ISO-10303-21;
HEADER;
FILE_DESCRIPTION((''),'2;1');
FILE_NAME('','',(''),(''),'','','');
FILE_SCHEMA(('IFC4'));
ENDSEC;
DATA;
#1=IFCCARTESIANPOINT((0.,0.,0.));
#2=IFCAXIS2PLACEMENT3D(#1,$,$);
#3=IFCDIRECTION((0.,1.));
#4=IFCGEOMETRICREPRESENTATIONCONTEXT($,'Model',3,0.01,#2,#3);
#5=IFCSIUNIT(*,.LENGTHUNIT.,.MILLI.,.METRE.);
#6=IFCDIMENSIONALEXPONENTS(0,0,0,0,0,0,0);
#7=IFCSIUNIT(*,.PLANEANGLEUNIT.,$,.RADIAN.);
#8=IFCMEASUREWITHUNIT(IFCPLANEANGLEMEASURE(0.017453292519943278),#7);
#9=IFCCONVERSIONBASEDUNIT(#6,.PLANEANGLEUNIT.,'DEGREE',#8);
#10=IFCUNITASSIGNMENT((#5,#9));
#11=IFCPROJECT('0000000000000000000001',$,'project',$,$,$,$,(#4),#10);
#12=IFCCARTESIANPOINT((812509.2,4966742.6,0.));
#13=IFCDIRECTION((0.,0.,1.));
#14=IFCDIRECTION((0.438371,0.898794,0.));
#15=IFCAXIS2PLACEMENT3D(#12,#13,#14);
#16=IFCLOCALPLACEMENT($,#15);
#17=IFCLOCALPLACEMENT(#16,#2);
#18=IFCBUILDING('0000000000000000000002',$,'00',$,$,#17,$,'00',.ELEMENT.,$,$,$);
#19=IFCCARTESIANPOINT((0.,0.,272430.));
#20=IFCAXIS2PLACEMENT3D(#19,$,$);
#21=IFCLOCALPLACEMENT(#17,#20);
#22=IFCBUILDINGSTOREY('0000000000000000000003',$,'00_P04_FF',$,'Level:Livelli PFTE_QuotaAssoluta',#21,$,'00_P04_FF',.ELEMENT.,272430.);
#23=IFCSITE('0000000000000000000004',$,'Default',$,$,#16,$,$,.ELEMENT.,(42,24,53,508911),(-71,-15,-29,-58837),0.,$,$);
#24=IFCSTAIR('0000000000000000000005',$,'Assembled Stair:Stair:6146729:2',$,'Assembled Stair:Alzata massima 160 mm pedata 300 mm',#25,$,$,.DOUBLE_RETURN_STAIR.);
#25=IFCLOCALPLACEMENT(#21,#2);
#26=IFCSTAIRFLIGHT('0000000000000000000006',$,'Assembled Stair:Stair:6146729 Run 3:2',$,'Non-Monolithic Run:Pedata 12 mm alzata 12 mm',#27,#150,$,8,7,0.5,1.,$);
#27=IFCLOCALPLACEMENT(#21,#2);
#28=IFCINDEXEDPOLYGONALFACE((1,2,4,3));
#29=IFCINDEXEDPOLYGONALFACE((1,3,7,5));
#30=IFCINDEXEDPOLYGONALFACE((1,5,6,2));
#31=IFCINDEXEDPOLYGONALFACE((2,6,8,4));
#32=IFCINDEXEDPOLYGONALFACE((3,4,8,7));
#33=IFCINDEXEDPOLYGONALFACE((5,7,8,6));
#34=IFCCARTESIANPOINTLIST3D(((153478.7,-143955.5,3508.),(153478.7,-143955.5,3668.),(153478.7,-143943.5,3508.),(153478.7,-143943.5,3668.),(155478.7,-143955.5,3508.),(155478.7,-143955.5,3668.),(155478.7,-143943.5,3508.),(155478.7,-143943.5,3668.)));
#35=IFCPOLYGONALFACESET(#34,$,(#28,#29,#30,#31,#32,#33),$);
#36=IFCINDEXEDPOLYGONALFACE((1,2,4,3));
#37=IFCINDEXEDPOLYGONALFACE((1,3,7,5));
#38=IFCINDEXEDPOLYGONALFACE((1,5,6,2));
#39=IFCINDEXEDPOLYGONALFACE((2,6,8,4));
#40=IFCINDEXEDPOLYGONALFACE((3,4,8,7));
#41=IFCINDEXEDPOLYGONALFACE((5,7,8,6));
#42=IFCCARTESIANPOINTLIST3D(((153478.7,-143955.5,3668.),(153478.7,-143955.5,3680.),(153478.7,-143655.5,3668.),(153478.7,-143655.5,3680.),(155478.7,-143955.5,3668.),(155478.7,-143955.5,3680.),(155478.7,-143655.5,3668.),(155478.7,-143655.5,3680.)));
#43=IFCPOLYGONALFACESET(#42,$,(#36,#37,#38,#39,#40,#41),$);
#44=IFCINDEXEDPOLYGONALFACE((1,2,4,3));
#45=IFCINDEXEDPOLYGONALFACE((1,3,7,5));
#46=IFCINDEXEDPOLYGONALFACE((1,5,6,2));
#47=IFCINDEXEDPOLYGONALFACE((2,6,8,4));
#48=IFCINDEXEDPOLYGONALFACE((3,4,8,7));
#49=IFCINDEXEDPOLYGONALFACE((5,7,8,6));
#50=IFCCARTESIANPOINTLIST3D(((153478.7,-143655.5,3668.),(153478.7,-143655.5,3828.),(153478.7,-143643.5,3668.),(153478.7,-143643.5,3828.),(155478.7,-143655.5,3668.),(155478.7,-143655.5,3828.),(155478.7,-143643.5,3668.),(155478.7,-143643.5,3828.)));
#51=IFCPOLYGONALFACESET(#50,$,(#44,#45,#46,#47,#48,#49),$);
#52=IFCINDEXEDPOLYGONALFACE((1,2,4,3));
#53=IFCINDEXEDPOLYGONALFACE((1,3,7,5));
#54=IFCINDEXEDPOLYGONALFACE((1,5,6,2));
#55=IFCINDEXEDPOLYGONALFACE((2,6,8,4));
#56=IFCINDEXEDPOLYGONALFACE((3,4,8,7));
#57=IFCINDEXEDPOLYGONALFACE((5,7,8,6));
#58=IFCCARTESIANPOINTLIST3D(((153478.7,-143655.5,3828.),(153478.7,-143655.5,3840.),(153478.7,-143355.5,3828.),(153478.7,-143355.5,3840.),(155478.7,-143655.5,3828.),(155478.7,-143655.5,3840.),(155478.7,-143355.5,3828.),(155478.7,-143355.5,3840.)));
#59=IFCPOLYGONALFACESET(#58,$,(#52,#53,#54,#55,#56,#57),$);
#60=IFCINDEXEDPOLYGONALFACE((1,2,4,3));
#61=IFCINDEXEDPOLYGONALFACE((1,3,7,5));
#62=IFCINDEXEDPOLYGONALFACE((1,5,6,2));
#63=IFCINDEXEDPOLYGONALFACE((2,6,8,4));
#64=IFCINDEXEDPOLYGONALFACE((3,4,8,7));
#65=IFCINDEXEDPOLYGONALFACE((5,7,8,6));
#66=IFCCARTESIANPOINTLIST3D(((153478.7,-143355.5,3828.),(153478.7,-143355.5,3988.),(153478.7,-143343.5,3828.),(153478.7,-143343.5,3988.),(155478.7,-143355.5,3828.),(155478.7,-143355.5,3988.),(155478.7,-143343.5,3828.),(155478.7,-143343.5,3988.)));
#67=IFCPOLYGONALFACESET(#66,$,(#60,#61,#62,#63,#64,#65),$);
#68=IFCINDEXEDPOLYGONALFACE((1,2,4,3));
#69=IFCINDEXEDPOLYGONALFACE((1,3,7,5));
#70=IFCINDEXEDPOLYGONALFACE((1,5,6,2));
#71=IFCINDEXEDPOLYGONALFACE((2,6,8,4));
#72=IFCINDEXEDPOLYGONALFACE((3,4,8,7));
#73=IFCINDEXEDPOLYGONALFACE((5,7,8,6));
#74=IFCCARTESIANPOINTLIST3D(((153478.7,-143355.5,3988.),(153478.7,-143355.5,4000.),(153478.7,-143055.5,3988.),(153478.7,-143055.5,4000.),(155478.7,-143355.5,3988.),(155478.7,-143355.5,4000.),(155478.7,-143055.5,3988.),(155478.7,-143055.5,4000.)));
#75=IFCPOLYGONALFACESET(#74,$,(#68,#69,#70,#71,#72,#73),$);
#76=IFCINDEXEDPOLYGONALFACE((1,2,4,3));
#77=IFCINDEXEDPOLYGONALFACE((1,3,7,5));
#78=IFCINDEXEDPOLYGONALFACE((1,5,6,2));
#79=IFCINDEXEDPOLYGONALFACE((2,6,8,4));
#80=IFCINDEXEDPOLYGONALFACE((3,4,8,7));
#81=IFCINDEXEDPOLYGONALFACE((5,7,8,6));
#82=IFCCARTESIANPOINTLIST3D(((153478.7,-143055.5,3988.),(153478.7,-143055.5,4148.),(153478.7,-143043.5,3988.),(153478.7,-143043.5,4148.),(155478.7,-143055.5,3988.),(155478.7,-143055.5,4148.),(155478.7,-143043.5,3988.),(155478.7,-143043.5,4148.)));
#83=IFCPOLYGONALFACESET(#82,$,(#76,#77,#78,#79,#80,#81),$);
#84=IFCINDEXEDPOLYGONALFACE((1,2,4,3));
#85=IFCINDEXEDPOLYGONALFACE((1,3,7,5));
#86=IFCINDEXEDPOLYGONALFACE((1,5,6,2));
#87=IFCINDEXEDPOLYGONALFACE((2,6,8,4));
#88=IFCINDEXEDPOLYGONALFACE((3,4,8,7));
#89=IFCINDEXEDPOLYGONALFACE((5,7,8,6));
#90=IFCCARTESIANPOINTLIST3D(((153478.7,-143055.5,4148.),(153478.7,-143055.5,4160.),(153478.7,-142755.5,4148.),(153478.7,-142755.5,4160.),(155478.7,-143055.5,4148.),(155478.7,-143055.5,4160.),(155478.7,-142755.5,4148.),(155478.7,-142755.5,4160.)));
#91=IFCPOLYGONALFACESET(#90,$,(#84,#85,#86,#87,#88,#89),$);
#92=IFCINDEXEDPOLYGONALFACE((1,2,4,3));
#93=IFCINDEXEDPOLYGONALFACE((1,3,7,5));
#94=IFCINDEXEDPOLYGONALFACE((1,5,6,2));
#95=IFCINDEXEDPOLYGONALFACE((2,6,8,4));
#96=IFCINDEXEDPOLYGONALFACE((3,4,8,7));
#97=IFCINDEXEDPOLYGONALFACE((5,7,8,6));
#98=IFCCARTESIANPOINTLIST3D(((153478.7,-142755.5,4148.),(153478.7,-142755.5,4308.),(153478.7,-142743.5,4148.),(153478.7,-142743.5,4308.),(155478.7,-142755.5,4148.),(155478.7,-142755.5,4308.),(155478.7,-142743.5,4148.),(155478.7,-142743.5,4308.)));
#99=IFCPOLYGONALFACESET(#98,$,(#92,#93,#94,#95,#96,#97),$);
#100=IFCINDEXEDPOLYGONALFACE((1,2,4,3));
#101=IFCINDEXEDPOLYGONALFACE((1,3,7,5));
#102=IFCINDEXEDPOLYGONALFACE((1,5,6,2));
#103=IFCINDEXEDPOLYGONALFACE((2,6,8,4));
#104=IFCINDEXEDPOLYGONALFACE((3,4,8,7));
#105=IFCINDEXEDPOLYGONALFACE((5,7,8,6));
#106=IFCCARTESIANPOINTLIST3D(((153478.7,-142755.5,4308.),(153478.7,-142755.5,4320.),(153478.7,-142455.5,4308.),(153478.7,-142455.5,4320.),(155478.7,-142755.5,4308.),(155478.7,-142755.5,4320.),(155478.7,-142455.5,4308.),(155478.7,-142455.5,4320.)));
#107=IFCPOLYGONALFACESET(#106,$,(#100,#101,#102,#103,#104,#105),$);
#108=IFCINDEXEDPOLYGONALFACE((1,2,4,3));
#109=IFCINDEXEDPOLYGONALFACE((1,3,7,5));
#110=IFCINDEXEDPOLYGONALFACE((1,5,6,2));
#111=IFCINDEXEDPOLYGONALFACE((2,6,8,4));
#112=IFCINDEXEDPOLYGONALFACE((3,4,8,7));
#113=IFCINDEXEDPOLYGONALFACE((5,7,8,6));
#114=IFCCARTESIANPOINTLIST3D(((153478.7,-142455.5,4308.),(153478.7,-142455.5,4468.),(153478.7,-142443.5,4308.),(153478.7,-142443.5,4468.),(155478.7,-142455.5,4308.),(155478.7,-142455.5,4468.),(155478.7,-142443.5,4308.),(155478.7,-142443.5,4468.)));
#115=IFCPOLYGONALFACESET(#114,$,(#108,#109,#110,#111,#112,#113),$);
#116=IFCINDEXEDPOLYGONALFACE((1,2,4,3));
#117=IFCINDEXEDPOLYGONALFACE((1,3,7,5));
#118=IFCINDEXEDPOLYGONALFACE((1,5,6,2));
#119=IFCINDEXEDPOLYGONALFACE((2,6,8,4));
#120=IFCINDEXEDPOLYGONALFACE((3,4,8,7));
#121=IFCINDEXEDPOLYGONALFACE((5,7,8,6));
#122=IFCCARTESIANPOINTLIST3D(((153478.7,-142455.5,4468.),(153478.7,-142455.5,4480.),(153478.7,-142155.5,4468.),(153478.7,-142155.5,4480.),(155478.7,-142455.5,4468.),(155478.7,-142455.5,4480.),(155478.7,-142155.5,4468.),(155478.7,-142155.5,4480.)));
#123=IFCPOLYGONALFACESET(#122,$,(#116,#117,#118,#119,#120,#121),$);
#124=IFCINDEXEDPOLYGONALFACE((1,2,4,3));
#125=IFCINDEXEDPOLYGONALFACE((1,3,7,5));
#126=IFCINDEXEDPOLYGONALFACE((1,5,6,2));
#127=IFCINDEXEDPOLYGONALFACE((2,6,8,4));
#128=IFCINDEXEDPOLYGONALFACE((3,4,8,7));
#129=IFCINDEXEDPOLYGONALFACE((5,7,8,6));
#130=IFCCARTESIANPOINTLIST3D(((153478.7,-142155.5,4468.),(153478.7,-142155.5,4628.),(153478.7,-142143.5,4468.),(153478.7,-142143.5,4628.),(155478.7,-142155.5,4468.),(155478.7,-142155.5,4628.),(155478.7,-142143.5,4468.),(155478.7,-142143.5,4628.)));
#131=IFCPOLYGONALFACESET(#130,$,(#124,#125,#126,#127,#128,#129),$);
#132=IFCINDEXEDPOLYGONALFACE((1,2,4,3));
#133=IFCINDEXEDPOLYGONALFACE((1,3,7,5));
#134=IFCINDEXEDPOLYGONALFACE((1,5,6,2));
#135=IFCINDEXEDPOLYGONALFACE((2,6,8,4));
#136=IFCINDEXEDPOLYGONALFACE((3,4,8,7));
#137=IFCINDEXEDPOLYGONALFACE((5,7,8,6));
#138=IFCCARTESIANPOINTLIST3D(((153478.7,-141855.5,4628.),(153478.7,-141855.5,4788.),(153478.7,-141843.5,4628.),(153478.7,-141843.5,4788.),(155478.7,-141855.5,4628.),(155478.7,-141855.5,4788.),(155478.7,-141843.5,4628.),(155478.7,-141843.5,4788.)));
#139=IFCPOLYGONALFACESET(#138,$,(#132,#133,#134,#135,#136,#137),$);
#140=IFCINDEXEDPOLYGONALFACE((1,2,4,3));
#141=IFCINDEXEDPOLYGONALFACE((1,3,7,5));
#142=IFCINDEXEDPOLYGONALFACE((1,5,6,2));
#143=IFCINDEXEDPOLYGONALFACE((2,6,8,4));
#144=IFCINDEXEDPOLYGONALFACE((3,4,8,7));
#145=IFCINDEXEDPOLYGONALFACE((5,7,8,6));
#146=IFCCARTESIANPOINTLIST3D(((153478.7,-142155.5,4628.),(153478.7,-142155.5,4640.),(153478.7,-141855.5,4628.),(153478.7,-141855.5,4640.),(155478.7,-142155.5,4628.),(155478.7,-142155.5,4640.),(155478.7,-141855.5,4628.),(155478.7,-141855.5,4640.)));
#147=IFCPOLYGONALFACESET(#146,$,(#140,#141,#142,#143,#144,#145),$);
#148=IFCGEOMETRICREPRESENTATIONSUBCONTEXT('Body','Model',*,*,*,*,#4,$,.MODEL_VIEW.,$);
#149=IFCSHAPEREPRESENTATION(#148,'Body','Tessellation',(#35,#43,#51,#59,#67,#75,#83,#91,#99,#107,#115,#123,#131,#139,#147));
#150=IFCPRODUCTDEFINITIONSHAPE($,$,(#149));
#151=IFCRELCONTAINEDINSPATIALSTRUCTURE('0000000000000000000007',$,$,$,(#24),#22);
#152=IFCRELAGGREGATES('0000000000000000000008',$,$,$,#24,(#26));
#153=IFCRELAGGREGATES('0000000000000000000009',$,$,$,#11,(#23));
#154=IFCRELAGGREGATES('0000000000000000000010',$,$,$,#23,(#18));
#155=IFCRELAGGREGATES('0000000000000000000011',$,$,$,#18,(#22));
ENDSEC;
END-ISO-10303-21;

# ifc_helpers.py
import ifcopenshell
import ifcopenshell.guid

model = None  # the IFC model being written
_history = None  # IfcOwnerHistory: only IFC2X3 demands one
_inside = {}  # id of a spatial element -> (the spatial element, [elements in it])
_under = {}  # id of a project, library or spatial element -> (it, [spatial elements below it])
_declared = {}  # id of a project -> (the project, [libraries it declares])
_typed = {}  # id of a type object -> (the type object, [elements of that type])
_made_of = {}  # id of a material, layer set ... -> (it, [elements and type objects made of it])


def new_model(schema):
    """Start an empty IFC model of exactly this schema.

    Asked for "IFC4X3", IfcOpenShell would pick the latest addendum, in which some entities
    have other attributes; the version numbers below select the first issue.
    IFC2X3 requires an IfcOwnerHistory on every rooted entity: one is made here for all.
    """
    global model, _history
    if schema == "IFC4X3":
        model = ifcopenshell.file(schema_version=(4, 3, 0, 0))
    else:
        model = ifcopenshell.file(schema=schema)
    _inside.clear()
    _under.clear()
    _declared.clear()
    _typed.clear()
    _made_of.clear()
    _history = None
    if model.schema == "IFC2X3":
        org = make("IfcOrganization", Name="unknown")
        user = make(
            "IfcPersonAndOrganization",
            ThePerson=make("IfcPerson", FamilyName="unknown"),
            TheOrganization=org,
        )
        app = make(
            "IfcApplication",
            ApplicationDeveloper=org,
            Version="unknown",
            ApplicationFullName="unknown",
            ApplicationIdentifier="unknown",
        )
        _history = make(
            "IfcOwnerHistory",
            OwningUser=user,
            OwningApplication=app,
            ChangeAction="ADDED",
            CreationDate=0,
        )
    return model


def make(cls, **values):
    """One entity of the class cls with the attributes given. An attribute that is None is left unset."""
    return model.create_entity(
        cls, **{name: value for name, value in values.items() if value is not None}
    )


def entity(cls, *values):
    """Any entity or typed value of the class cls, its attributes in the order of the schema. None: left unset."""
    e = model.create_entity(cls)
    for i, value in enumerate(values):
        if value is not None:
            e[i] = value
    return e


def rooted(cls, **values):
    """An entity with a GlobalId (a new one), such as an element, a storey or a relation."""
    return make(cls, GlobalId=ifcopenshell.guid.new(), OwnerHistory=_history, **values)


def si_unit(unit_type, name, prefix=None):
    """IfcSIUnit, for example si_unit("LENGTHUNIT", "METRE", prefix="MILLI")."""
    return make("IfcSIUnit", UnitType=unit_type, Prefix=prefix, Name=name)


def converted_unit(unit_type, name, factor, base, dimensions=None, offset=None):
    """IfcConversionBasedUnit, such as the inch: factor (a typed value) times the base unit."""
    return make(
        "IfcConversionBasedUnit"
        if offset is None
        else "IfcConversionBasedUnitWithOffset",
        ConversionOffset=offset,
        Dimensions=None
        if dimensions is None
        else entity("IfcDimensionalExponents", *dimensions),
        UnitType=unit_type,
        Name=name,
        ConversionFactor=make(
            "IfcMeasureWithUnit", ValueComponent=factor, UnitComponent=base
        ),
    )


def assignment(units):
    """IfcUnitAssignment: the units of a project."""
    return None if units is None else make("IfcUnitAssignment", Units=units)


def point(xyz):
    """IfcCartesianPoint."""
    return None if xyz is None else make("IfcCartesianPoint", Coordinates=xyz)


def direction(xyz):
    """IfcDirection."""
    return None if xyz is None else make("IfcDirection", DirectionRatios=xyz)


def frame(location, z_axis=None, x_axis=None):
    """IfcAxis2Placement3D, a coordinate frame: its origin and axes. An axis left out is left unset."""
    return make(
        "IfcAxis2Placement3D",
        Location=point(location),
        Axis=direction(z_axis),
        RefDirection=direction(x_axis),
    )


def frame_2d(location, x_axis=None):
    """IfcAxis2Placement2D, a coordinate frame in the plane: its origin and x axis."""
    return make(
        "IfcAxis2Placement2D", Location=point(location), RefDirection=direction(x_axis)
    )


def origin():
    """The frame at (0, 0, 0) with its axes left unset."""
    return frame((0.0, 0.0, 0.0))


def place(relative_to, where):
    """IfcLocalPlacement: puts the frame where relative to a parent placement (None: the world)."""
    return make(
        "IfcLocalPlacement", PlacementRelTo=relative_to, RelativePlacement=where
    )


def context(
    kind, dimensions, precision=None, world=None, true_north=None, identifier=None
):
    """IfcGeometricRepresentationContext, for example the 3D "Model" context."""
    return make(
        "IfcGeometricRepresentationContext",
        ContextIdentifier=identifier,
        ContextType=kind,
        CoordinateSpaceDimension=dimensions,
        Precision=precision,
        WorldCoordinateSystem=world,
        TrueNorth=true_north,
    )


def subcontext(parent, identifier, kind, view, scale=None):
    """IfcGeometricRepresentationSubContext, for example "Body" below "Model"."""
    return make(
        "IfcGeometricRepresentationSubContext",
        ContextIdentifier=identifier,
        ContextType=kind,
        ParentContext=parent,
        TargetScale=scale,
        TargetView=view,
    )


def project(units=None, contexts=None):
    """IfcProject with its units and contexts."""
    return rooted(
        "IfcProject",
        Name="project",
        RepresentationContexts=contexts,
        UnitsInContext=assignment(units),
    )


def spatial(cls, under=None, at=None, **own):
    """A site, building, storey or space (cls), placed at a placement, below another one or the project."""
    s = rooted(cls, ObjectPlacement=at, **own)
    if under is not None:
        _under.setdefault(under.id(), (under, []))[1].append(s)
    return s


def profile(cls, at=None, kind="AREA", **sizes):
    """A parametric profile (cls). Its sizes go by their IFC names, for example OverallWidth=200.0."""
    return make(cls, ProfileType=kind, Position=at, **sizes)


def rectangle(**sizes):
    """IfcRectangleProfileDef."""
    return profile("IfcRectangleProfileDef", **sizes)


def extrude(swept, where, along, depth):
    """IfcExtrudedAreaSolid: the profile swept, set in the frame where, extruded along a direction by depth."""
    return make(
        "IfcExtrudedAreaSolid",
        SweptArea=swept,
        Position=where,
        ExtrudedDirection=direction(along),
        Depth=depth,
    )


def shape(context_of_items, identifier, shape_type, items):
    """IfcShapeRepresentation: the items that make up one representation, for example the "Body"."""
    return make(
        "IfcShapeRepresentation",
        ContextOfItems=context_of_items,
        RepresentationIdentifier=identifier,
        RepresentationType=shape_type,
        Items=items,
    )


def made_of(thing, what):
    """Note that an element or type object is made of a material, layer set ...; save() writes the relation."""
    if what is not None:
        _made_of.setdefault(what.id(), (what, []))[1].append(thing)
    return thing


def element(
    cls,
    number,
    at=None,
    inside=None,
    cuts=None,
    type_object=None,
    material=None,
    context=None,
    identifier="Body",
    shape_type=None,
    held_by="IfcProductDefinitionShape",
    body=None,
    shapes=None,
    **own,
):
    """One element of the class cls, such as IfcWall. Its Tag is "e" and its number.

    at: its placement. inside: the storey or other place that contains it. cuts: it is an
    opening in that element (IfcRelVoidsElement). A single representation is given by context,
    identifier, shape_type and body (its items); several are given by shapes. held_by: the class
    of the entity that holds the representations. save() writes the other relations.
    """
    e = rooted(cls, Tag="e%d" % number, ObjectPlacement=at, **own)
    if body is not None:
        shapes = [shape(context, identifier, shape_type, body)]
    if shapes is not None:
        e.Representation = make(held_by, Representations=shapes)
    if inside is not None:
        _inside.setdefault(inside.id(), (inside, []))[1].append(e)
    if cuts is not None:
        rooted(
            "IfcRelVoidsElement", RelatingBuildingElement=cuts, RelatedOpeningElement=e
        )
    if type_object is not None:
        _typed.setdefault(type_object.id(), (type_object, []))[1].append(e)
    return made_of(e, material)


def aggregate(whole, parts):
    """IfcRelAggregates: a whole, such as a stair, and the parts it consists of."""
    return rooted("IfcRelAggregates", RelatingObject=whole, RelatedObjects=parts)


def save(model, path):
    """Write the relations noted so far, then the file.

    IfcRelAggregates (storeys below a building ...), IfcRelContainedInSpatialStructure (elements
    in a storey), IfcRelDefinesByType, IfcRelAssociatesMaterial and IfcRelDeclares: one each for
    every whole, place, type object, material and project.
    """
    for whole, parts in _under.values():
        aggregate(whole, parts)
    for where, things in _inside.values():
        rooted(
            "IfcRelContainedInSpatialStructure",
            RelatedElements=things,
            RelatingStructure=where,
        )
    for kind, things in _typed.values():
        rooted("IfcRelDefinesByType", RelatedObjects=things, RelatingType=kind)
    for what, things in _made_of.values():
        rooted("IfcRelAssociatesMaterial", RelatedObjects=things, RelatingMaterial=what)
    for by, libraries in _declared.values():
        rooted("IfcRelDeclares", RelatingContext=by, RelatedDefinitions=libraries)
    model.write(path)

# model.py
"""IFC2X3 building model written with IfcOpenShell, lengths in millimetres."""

from ifc_helpers import new_model, entity, si_unit, converted_unit, direction, frame, frame_2d, origin, place, context, subcontext, project, spatial, rectangle, extrude, element, aggregate, save


model = new_model("IFC2X3")

# Units and contexts
model_context = context("Model", 3, precision=0.01, world=origin(), true_north=direction((0.0, 1.0)))
body_context = subcontext(model_context, "Body", "Model", "MODEL_VIEW")
ifc_project = project(units=[si_unit("LENGTHUNIT", "METRE", prefix="MILLI"), converted_unit("PLANEANGLEUNIT", "DEGREE", entity("IfcPlaneAngleMeasure", 0.017453292519943278), si_unit("PLANEANGLEUNIT", "RADIAN"), dimensions=[0, 0, 0, 0, 0, 0, 0])], contexts=[model_context])

# Site, building, storey
site_placement = place(None, frame((812509.2, 4966742.6, 0.0), z_axis=(0.0, 0.0, 1.0), x_axis=(0.438371, 0.898794, 0.0)))
site = spatial("IfcSite", under=ifc_project, at=site_placement, Name="Default", CompositionType="ELEMENT", RefLatitude=(42, 24, 53, 508911), RefLongitude=(-71, -15, -29, -58837), RefElevation=0.0)
building_placement = place(site_placement, origin())
building = spatial("IfcBuilding", under=site, at=building_placement, Name="00", LongName="00", CompositionType="ELEMENT")
storey_placement = place(building_placement, frame((0.0, 0.0, 272430.0)))
storey = spatial("IfcBuildingStorey", under=building, at=storey_placement, Name="00_P04_FF", ObjectType="Level:Livelli PFTE_QuotaAssoluta", LongName="00_P04_FF", CompositionType="ELEMENT", Elevation=272430.0)

# Stair
stair_1_placement = place(storey_placement, origin())
stair_1 = element("IfcStair", 1, at=stair_1_placement, inside=storey, Name="Assembled Stair:Stair:6146729:2", ObjectType="Assembled Stair:Alzata massima 160 mm pedata 300 mm", ShapeType="DOUBLE_RETURN_STAIR")

# Stair flight
stair_flight_1_placement = place(stair_1_placement, origin())
stair_flight_1 = element("IfcStairFlight", 2, at=stair_flight_1_placement, Name="Assembled Stair:Stair:6146729 Run 3:2", ObjectType="Non-Monolithic Run:Pedata 12 mm alzata 12 mm", NumberOfRiser=8, NumberOfTreads=7, RiserHeight=0.5, TreadLength=1.0, context=body_context, shape_type="SweptSolid", body=[
    extrude(rectangle(XDim=2000.0, YDim=12.0, at=frame_2d((0.0, 0.0), x_axis=(1.0, 0.0))), frame((154478.7, -143949.5, 3508.0), z_axis=(0.0, 0.0, 1.0), x_axis=(-1.0, 0.0, 0.0)), (0.0, 0.0, 1.0), 160.0),
    extrude(rectangle(XDim=300.0, YDim=2000.0, at=frame_2d((0.0, 0.0), x_axis=(1.0, 0.0))), frame((154478.7, -143805.5, 3668.0), z_axis=(0.0, 0.0, 1.0), x_axis=(0.0, -1.0, 0.0)), (0.0, 0.0, 1.0), 12.0),
    extrude(rectangle(XDim=2000.0, YDim=12.0, at=frame_2d((0.0, 0.0), x_axis=(1.0, 0.0))), frame((154478.7, -143649.5, 3668.0), z_axis=(0.0, 0.0, 1.0), x_axis=(-1.0, 0.0, 0.0)), (0.0, 0.0, 1.0), 160.0),
    extrude(rectangle(XDim=300.0, YDim=2000.0, at=frame_2d((0.0, 0.0), x_axis=(1.0, 0.0))), frame((154478.7, -143505.5, 3828.0), z_axis=(0.0, 0.0, 1.0), x_axis=(0.0, -1.0, 0.0)), (0.0, 0.0, 1.0), 12.0),
    extrude(rectangle(XDim=2000.0, YDim=12.0, at=frame_2d((0.0, 0.0), x_axis=(1.0, 0.0))), frame((154478.7, -143349.5, 3828.0), z_axis=(0.0, 0.0, 1.0), x_axis=(-1.0, 0.0, 0.0)), (0.0, 0.0, 1.0), 160.0),
    extrude(rectangle(XDim=300.0, YDim=2000.0, at=frame_2d((0.0, 0.0), x_axis=(1.0, 0.0))), frame((154478.7, -143205.5, 3988.0), z_axis=(0.0, 0.0, 1.0), x_axis=(0.0, -1.0, 0.0)), (0.0, 0.0, 1.0), 12.0),
    extrude(rectangle(XDim=2000.0, YDim=12.0, at=frame_2d((0.0, 0.0), x_axis=(1.0, 0.0))), frame((154478.7, -143049.5, 3988.0), z_axis=(0.0, 0.0, 1.0), x_axis=(-1.0, 0.0, 0.0)), (0.0, 0.0, 1.0), 160.0),
    extrude(rectangle(XDim=300.0, YDim=2000.0, at=frame_2d((0.0, 0.0), x_axis=(1.0, 0.0))), frame((154478.7, -142905.5, 4148.0), z_axis=(0.0, 0.0, 1.0), x_axis=(0.0, -1.0, 0.0)), (0.0, 0.0, 1.0), 12.0),
    extrude(rectangle(XDim=2000.0, YDim=12.0, at=frame_2d((0.0, 0.0), x_axis=(1.0, 0.0))), frame((154478.7, -142749.5, 4148.0), z_axis=(0.0, 0.0, 1.0), x_axis=(-1.0, 0.0, 0.0)), (0.0, 0.0, 1.0), 160.0),
    extrude(rectangle(XDim=300.0, YDim=2000.0, at=frame_2d((0.0, 0.0), x_axis=(1.0, 0.0))), frame((154478.7, -142605.5, 4308.0), z_axis=(0.0, 0.0, 1.0), x_axis=(0.0, -1.0, 0.0)), (0.0, 0.0, 1.0), 12.0),
    extrude(rectangle(XDim=2000.0, YDim=12.0, at=frame_2d((0.0, 0.0), x_axis=(1.0, 0.0))), frame((154478.7, -142449.5, 4308.0), z_axis=(0.0, 0.0, 1.0), x_axis=(-1.0, 0.0, 0.0)), (0.0, 0.0, 1.0), 160.0),
    extrude(rectangle(XDim=300.0, YDim=2000.0, at=frame_2d((0.0, 0.0), x_axis=(1.0, 0.0))), frame((154478.7, -142305.5, 4468.0), z_axis=(0.0, 0.0, 1.0), x_axis=(0.0, -1.0, 0.0)), (0.0, 0.0, 1.0), 12.0),
    extrude(rectangle(XDim=2000.0, YDim=12.0, at=frame_2d((0.0, 0.0), x_axis=(1.0, 0.0))), frame((154478.7, -142149.5, 4468.0), z_axis=(0.0, 0.0, 1.0), x_axis=(-1.0, 0.0, 0.0)), (0.0, 0.0, 1.0), 160.0),
    extrude(rectangle(XDim=2000.0, YDim=12.0, at=frame_2d((0.0, 0.0), x_axis=(1.0, 0.0))), frame((154478.7, -141849.5, 4628.0), z_axis=(0.0, 0.0, 1.0), x_axis=(-1.0, 0.0, 0.0)), (0.0, 0.0, 1.0), 160.0),
    extrude(rectangle(XDim=300.0, YDim=2000.0, at=frame_2d((0.0, 0.0), x_axis=(1.0, 0.0))), frame((154478.7, -142005.5, 4628.0), z_axis=(0.0, 0.0, 1.0), x_axis=(0.0, -1.0, 0.0)), (0.0, 0.0, 1.0), 12.0),
])
aggregate(stair_1, [stair_flight_1])

save(model, "model.ifc")
